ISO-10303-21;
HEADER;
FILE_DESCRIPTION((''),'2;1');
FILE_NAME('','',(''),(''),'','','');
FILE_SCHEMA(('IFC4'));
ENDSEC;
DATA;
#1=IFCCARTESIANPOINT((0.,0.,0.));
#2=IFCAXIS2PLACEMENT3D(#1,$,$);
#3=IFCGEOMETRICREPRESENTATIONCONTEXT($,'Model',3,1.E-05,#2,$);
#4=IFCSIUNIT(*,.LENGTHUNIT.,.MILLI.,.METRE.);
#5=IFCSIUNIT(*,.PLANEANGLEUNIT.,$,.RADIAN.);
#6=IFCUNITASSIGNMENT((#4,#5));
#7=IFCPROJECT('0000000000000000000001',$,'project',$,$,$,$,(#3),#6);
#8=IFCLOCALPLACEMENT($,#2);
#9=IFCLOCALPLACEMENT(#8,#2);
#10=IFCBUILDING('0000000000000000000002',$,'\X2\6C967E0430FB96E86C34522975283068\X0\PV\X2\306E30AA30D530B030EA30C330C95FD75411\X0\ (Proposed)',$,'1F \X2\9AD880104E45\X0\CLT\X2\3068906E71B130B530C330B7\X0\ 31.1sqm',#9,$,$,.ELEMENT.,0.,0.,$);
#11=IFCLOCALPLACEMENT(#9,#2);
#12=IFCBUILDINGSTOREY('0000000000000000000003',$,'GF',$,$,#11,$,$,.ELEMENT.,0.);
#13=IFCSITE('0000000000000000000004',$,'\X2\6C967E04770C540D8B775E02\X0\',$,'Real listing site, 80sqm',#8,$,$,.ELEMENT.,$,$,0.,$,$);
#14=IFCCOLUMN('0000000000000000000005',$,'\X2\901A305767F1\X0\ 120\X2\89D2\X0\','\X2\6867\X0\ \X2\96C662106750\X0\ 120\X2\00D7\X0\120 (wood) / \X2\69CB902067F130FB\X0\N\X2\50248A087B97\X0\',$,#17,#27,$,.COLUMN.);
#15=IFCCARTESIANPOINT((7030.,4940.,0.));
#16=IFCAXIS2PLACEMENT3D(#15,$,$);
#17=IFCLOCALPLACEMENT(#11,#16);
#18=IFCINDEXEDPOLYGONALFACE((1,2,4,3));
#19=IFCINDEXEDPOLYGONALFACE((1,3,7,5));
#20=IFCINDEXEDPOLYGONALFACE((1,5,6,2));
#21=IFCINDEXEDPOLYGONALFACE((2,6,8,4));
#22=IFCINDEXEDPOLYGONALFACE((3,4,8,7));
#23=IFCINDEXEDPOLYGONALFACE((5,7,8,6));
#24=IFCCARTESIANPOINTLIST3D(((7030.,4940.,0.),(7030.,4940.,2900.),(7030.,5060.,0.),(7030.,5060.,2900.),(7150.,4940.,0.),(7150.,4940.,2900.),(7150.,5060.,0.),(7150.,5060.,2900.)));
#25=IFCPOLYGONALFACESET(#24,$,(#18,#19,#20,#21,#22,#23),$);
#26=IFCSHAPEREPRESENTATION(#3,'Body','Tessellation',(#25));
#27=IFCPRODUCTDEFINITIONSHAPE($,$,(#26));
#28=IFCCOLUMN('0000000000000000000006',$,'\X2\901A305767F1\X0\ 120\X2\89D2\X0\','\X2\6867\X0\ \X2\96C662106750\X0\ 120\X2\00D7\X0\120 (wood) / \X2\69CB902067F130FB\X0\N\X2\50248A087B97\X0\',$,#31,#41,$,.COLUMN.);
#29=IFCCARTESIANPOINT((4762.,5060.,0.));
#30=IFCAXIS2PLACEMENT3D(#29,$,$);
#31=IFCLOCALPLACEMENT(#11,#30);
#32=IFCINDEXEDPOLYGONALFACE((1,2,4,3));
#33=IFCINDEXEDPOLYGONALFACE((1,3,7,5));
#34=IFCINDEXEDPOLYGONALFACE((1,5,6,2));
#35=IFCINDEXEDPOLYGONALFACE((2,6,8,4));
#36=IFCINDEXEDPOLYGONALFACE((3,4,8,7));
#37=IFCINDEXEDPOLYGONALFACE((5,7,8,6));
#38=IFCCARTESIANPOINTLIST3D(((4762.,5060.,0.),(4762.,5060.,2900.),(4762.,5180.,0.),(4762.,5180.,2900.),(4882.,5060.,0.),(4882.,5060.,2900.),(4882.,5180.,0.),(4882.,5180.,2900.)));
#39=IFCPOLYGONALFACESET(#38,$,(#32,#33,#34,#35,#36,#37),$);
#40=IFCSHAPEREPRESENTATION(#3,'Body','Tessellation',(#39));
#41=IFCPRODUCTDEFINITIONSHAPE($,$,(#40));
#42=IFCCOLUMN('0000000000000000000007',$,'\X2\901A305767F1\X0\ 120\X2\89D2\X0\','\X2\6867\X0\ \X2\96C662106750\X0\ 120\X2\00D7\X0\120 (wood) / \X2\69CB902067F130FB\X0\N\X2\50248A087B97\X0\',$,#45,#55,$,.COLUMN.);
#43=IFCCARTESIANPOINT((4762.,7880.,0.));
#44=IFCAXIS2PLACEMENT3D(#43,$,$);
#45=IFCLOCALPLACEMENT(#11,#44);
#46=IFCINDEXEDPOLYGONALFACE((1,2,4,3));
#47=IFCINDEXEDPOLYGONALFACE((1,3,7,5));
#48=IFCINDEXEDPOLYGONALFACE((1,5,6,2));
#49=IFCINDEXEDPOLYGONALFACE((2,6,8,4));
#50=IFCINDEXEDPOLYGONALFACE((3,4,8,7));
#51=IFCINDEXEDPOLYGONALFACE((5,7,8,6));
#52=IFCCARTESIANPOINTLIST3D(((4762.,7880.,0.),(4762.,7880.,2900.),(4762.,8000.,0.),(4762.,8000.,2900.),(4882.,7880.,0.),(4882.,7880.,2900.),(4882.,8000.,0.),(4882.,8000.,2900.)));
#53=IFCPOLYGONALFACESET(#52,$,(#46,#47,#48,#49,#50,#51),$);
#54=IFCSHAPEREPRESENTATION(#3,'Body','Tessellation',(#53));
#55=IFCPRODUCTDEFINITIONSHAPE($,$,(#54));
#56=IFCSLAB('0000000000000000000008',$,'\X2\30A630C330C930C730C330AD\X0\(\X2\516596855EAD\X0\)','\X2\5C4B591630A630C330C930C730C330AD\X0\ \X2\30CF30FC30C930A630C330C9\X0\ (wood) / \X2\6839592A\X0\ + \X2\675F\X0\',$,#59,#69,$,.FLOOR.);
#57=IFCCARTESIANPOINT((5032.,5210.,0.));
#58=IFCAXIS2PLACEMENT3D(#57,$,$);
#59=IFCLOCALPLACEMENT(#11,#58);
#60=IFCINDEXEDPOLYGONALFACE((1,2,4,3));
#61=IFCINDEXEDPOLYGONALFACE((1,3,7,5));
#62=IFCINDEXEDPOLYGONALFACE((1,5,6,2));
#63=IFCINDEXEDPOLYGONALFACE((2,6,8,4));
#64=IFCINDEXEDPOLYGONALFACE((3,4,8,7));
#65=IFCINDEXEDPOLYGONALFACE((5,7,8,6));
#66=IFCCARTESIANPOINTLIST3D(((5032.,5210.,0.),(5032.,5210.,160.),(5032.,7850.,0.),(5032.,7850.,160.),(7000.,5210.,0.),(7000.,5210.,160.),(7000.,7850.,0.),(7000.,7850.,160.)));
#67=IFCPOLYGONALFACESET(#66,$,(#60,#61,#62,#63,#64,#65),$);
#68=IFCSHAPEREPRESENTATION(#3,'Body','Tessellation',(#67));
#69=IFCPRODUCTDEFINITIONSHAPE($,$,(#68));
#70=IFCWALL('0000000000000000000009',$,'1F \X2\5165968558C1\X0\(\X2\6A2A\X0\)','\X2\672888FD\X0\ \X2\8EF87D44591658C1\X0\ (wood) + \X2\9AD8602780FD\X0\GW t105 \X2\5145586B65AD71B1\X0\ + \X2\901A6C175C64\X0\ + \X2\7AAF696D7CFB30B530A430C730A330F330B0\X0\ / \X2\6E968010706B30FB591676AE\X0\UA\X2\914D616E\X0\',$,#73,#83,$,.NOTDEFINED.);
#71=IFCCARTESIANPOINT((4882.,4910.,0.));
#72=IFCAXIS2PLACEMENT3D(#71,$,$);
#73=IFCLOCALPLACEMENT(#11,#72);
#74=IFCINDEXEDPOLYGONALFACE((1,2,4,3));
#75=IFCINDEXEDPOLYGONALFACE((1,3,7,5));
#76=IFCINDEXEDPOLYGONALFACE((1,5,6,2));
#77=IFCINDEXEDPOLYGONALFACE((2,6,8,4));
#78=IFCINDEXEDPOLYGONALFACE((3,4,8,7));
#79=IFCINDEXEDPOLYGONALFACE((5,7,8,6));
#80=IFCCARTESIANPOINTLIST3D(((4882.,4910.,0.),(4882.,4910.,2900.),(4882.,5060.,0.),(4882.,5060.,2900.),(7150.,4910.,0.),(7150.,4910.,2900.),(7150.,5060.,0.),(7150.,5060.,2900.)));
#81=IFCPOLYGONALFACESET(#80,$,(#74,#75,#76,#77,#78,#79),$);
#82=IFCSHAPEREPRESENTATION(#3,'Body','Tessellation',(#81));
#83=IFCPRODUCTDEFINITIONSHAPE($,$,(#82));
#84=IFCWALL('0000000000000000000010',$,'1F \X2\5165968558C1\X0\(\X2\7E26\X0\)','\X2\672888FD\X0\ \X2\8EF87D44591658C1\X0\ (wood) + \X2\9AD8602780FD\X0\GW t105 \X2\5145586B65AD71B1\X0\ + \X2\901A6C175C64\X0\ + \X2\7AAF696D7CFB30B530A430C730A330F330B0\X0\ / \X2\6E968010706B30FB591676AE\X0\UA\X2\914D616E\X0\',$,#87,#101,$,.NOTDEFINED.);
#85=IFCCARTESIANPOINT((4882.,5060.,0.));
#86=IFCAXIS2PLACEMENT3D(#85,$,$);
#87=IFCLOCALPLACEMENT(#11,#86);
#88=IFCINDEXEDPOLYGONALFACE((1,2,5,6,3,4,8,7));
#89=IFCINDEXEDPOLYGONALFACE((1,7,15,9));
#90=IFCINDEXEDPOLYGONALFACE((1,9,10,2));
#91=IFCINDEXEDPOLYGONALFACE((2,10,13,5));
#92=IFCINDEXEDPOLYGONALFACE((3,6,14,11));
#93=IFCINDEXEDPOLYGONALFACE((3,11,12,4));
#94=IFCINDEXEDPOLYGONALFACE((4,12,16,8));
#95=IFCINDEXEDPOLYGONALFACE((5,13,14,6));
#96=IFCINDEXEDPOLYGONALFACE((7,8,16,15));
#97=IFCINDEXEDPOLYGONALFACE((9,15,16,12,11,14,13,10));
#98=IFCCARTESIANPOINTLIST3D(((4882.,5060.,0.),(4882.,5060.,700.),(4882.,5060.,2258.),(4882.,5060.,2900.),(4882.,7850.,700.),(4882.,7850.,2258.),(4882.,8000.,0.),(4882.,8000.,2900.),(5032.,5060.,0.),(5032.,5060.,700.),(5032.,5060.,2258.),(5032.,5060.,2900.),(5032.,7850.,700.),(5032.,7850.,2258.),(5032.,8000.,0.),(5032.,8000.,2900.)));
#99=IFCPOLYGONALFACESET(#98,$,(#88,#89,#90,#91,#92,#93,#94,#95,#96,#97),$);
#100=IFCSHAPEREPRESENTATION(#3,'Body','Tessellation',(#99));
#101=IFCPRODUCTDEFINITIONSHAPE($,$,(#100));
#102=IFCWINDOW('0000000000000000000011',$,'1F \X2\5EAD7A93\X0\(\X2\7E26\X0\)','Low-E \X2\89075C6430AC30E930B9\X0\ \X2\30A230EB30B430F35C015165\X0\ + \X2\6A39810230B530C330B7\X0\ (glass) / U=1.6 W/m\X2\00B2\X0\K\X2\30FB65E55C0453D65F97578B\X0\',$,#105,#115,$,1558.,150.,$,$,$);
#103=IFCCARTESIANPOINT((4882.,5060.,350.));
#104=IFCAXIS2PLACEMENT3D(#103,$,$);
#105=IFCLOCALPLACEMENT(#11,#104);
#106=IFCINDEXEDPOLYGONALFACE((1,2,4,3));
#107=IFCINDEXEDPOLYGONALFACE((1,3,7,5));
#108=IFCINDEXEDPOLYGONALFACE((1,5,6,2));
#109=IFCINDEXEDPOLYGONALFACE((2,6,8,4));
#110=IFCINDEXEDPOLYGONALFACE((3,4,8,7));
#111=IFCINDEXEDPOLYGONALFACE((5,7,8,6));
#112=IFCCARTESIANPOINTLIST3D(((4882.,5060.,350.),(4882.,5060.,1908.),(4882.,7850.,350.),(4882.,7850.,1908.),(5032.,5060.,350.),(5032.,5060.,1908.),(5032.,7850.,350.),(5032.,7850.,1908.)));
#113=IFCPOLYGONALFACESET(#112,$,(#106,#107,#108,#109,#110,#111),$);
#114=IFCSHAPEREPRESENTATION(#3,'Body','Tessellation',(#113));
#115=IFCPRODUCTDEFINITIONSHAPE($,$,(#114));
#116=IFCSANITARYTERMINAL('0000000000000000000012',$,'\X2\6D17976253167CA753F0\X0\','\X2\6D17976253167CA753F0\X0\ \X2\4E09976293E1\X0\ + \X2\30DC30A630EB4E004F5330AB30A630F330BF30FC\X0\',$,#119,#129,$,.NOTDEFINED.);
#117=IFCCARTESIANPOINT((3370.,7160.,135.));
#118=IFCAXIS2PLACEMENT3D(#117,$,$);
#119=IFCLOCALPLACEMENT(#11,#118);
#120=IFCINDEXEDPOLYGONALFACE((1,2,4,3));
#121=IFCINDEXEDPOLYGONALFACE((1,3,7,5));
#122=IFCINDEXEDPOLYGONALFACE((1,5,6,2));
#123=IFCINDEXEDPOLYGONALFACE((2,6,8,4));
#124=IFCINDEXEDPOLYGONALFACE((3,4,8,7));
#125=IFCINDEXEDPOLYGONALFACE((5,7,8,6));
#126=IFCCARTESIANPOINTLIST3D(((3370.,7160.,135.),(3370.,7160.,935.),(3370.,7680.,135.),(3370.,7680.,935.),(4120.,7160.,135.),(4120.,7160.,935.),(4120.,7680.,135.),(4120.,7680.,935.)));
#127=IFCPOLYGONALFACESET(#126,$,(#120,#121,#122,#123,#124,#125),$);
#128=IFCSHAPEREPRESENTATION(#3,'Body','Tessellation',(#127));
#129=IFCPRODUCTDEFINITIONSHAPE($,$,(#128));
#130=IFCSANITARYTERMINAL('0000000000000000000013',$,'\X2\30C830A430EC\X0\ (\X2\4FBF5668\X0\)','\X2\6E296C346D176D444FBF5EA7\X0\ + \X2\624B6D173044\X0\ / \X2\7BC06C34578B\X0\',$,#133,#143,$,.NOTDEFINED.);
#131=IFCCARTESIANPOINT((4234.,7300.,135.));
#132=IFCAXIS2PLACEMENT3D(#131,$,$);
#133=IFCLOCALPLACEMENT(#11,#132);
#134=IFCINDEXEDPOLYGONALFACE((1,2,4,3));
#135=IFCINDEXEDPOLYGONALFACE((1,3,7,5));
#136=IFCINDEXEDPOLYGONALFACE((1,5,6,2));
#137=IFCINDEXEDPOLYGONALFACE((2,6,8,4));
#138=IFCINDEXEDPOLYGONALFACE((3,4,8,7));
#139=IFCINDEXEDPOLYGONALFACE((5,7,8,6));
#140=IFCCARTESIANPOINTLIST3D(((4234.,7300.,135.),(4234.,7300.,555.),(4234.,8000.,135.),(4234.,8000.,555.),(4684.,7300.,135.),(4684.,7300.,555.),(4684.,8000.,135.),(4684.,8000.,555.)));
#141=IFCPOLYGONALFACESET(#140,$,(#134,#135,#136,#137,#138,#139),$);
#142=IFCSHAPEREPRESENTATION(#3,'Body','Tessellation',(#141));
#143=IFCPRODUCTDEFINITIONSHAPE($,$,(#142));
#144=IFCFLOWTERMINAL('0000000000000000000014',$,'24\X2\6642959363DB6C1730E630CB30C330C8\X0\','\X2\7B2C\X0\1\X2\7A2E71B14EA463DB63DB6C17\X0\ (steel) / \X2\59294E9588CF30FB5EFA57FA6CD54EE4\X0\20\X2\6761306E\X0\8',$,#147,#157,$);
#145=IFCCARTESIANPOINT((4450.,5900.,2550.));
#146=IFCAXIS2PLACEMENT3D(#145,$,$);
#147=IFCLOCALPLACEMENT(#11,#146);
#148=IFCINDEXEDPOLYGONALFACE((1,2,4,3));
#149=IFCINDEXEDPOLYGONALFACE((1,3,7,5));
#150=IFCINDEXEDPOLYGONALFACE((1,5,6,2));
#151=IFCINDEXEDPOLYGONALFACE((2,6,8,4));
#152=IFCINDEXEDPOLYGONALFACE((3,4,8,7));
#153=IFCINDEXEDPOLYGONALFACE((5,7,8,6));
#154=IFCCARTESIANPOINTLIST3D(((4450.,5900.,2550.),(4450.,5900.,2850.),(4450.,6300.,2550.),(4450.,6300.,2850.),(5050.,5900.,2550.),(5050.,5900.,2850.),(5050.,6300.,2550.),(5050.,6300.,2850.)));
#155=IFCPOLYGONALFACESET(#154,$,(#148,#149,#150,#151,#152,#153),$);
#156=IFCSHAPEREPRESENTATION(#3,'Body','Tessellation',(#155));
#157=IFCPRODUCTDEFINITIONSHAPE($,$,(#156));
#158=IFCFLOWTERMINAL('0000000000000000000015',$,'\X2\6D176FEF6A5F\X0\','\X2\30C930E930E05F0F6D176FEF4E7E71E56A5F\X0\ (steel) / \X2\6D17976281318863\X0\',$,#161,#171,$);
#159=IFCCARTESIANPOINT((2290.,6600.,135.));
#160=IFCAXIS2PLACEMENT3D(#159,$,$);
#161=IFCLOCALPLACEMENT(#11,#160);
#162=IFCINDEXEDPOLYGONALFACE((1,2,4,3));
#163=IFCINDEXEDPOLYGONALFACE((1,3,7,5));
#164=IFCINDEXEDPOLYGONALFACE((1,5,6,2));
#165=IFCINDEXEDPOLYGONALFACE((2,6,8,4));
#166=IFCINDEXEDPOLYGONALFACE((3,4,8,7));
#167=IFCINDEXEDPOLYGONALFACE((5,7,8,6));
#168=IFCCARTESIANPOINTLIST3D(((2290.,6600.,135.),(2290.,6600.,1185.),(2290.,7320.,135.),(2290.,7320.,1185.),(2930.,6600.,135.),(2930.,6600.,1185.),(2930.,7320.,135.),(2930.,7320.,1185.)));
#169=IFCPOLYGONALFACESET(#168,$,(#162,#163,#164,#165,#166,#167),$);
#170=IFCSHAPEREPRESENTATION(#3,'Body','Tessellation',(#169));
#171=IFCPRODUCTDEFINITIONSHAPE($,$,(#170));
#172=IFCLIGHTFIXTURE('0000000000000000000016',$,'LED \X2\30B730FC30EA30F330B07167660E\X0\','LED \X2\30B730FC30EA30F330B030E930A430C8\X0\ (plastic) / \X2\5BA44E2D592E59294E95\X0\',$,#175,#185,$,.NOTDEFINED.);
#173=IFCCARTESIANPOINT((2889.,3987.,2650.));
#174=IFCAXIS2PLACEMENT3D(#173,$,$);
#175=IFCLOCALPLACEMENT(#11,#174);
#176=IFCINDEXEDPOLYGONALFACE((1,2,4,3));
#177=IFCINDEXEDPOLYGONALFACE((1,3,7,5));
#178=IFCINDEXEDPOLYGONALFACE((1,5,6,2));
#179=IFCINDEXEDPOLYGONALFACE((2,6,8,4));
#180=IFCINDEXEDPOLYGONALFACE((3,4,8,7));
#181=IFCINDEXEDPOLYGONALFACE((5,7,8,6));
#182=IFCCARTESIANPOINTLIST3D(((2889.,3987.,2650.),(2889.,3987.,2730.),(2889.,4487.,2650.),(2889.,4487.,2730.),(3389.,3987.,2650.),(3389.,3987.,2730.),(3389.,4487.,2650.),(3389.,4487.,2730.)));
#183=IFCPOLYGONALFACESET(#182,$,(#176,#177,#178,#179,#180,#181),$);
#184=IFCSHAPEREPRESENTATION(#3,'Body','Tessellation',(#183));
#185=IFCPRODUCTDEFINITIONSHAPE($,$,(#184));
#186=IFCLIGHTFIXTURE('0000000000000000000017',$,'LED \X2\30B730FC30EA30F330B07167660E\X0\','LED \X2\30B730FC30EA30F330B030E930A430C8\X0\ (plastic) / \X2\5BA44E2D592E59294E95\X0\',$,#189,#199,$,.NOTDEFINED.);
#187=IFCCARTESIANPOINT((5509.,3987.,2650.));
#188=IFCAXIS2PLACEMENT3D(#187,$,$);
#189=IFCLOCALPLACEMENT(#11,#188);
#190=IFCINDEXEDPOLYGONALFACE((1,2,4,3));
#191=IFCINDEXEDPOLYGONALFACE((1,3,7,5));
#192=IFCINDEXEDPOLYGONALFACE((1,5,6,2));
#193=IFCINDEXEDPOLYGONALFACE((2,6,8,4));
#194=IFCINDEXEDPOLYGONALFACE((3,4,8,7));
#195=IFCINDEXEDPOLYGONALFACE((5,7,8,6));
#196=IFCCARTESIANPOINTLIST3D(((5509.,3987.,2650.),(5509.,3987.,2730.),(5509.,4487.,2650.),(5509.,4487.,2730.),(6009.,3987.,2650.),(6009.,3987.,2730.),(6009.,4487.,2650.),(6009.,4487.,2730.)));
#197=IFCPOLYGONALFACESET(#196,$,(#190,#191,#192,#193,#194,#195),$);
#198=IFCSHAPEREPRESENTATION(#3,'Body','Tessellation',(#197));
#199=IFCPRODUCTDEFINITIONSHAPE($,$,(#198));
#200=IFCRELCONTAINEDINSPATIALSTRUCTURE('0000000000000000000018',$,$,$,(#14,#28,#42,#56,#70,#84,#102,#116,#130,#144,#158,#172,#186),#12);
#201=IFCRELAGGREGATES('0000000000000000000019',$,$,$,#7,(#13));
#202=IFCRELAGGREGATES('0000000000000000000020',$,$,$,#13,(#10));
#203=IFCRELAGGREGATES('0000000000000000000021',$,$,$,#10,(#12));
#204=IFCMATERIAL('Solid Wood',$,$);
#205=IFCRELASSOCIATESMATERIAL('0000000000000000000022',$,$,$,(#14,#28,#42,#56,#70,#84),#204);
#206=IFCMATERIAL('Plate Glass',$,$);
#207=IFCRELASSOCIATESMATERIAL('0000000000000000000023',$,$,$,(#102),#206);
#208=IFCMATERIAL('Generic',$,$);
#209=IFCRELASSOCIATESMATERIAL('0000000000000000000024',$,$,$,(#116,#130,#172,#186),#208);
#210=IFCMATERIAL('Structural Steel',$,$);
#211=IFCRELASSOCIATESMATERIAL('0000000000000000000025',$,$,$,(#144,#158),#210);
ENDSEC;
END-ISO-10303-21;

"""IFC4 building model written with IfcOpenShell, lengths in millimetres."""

from ifc_helpers import new_model, si_unit, frame, frame_2d, origin, place, context, project, spatial, rectangle, extrude, material, element, fill, save


model = new_model("IFC4")

# Units and contexts
model_context = context("Model", 3, precision=1e-05, world=origin())
ifc_project = project(units=[si_unit("LENGTHUNIT", "METRE", prefix="MILLI"), si_unit("PLANEANGLEUNIT", "RADIAN")], contexts=[model_context])

# Site, building, storey
site_placement = place(None, origin())
site = spatial("IfcSite", under=ifc_project, at=site_placement, Name="沖縄県名護市", ObjectType="Real listing site, 80sqm", CompositionType="ELEMENT", RefElevation=0.0)
building_placement = place(site_placement, origin())
building = spatial("IfcBuilding", under=site, at=building_placement, Name="沖縄・雨水利用とPVのオフグリッド志向 (Proposed)", ObjectType="1F 高耐久CLTと遮熱サッシ 31.1sqm", CompositionType="ELEMENT", ElevationOfRefHeight=0.0, ElevationOfTerrain=0.0)
storey_placement = place(building_placement, origin())
storey = spatial("IfcBuildingStorey", under=building, at=storey_placement, Name="GF", CompositionType="ELEMENT", Elevation=0.0)

# Columns
ifc_material_1 = material(Name="Solid Wood")
column_1_placement = place(storey_placement, frame((7030.0, 4940.0, 0.0)))
element("IfcColumn", 1, at=column_1_placement, inside=storey, material=ifc_material_1, Name="通し柱 120角", Description="桧 集成材 120×120 (wood) / 構造柱・N値計算", PredefinedType="COLUMN", context=model_context, shape_type="SweptSolid", body=[
    extrude(rectangle(XDim=120.0, YDim=120.0, at=frame_2d((60.0, 60.0))), frame((7030.0, 4940.0, 0.0)), (0.0, 0.0, 1.0), 2900.0),
])
column_2_placement = place(storey_placement, frame((4762.0, 5060.0, 0.0)))
element("IfcColumn", 2, at=column_2_placement, inside=storey, material=ifc_material_1, Name="通し柱 120角", Description="桧 集成材 120×120 (wood) / 構造柱・N値計算", PredefinedType="COLUMN", context=model_context, shape_type="SweptSolid", body=[
    extrude(rectangle(XDim=120.0, YDim=120.0, at=frame_2d((60.0, 60.0))), frame((4762.0, 5060.0, 0.0)), (0.0, 0.0, 1.0), 2900.0),
])
column_3_placement = place(storey_placement, frame((4762.0, 7880.0, 0.0)))
element("IfcColumn", 3, at=column_3_placement, inside=storey, material=ifc_material_1, Name="通し柱 120角", Description="桧 集成材 120×120 (wood) / 構造柱・N値計算", PredefinedType="COLUMN", context=model_context, shape_type="SweptSolid", body=[
    extrude(rectangle(XDim=120.0, YDim=120.0, at=frame_2d((60.0, 60.0))), frame((4762.0, 7880.0, 0.0)), (0.0, 0.0, 1.0), 2900.0),
])

# Slab
slab_placement = place(storey_placement, frame((5032.0, 5210.0, 0.0)))
element("IfcSlab", 4, at=slab_placement, inside=storey, material=ifc_material_1, Name="ウッドデッキ(入隅庭)", Description="屋外ウッドデッキ ハードウッド (wood) / 根太 + 束", PredefinedType="FLOOR", context=model_context, shape_type="SweptSolid", body=[
    extrude(rectangle(XDim=1968.0, YDim=2640.0, at=frame_2d((984.0, 1320.0))), frame((5032.0, 5210.0, 0.0)), (0.0, 0.0, 1.0), 160.0),
])

# Wall
wall_1_placement = place(storey_placement, frame((4882.0, 4910.0, 0.0)))
element("IfcWall", 5, at=wall_1_placement, inside=storey, material=ifc_material_1, Name="1F 入隅壁(横)", Description="木製 軸組外壁 (wood) + 高性能GW t105 充填断熱 + 通気層 + 窯業系サイディング / 準耐火・外皮UA配慮", PredefinedType="NOTDEFINED", context=model_context, shape_type="SweptSolid", body=[
    extrude(rectangle(XDim=2268.0, YDim=150.0, at=frame_2d((1134.0, 75.0))), frame((4882.0, 4910.0, 0.0)), (0.0, 0.0, 1.0), 2900.0),
])

# Wall, opening, window
wall_2_placement = place(storey_placement, frame((4882.0, 5060.0, 0.0)))
wall_2 = element("IfcWall", 6, at=wall_2_placement, inside=storey, material=ifc_material_1, Name="1F 入隅壁(縦)", Description="木製 軸組外壁 (wood) + 高性能GW t105 充填断熱 + 通気層 + 窯業系サイディング / 準耐火・外皮UA配慮", PredefinedType="NOTDEFINED", context=model_context, shape_type="SweptSolid", body=[
    extrude(rectangle(XDim=150.0, YDim=2940.0, at=frame_2d((75.0, 1470.0))), frame((4882.0, 5060.0, 0.0)), (0.0, 0.0, 1.0), 2900.0),
])
opening_placement = place(storey_placement, frame((4882.0, 5060.0, 350.0)))
opening = element("IfcOpeningElement", 7, at=opening_placement, cuts=wall_2, PredefinedType="NOTDEFINED", context=model_context, shape_type="SweptSolid", body=[
    extrude(rectangle(XDim=150.0, YDim=2790.0, at=frame_2d((75.0, 1395.0))), frame((4882.0, 5060.0, 350.0)), (0.0, 0.0, 1.0), 1558.0),
])
ifc_material_2 = material(Name="Plate Glass")
window_placement = place(storey_placement, frame((4882.0, 5060.0, 350.0)))
window = element("IfcWindow", 8, at=window_placement, inside=storey, material=ifc_material_2, Name="1F 庭窓(縦)", Description="Low-E 複層ガラス アルゴン封入 + 樹脂サッシ (glass) / U=1.6 W/m²K・日射取得型", OverallHeight=1558.0, OverallWidth=150.0, context=model_context, shape_type="SweptSolid", body=[
    extrude(rectangle(XDim=150.0, YDim=2790.0, at=frame_2d((75.0, 1395.0))), frame((4882.0, 5060.0, 350.0)), (0.0, 0.0, 1.0), 1558.0),
])
fill(opening, window)

# Sanitary terminals
ifc_material_3 = material(Name="Generic")
sanitary_terminal_1_placement = place(storey_placement, frame((3370.0, 7160.0, 135.0)))
element("IfcSanitaryTerminal", 9, at=sanitary_terminal_1_placement, inside=storey, material=ifc_material_3, Name="洗面化粧台", Description="洗面化粧台 三面鏡 + ボウル一体カウンター", PredefinedType="NOTDEFINED", context=model_context, shape_type="SweptSolid", body=[
    extrude(rectangle(XDim=750.0, YDim=520.0, at=frame_2d((375.0, 260.0))), frame((3370.0, 7160.0, 135.0)), (0.0, 0.0, 1.0), 800.0),
])
sanitary_terminal_2_placement = place(storey_placement, frame((4234.0, 7300.0, 135.0)))
element("IfcSanitaryTerminal", 10, at=sanitary_terminal_2_placement, inside=storey, material=ifc_material_3, Name="トイレ (便器)", Description="温水洗浄便座 + 手洗い / 節水型", PredefinedType="NOTDEFINED", context=model_context, shape_type="SweptSolid", body=[
    extrude(rectangle(XDim=450.0, YDim=700.0, at=frame_2d((225.0, 350.0))), frame((4234.0, 7300.0, 135.0)), (0.0, 0.0, 1.0), 420.0),
])

# Flow terminals
ifc_material_4 = material(Name="Structural Steel")
flow_terminal_1_placement = place(storey_placement, frame((4450.0, 5900.0, 2550.0)))
element("IfcFlowTerminal", 11, at=flow_terminal_1_placement, inside=storey, material=ifc_material_4, Name="24時間換気ユニット", Description="第1種熱交換換気 (steel) / 天井裏・建基法令20条の8", context=model_context, shape_type="SweptSolid", body=[
    extrude(rectangle(XDim=600.0, YDim=400.0, at=frame_2d((300.0, 200.0))), frame((4450.0, 5900.0, 2550.0)), (0.0, 0.0, 1.0), 300.0),
])
flow_terminal_2_placement = place(storey_placement, frame((2290.0, 6600.0, 135.0)))
element("IfcFlowTerminal", 12, at=flow_terminal_2_placement, inside=storey, material=ifc_material_4, Name="洗濯機", Description="ドラム式洗濯乾燥機 (steel) / 洗面脱衣", context=model_context, shape_type="SweptSolid", body=[
    extrude(rectangle(XDim=640.0, YDim=720.0, at=frame_2d((320.0, 360.0))), frame((2290.0, 6600.0, 135.0)), (0.0, 0.0, 1.0), 1050.0),
])

# Light fixtures
light_fixture_1_placement = place(storey_placement, frame((2889.0, 3987.0, 2650.0)))
element("IfcLightFixture", 13, at=light_fixture_1_placement, inside=storey, material=ifc_material_3, Name="LED シーリング照明", Description="LED シーリングライト (plastic) / 室中央天井", PredefinedType="NOTDEFINED", context=model_context, shape_type="SweptSolid", body=[
    extrude(rectangle(XDim=500.0, YDim=500.0, at=frame_2d((250.0, 250.0))), frame((2889.0, 3987.0, 2650.0)), (0.0, 0.0, 1.0), 80.0),
])
light_fixture_2_placement = place(storey_placement, frame((5509.0, 3987.0, 2650.0)))
element("IfcLightFixture", 14, at=light_fixture_2_placement, inside=storey, material=ifc_material_3, Name="LED シーリング照明", Description="LED シーリングライト (plastic) / 室中央天井", PredefinedType="NOTDEFINED", context=model_context, shape_type="SweptSolid", body=[
    extrude(rectangle(XDim=500.0, YDim=500.0, at=frame_2d((250.0, 250.0))), frame((5509.0, 3987.0, 2650.0)), (0.0, 0.0, 1.0), 80.0),
])

save(model, "model.ifc")
